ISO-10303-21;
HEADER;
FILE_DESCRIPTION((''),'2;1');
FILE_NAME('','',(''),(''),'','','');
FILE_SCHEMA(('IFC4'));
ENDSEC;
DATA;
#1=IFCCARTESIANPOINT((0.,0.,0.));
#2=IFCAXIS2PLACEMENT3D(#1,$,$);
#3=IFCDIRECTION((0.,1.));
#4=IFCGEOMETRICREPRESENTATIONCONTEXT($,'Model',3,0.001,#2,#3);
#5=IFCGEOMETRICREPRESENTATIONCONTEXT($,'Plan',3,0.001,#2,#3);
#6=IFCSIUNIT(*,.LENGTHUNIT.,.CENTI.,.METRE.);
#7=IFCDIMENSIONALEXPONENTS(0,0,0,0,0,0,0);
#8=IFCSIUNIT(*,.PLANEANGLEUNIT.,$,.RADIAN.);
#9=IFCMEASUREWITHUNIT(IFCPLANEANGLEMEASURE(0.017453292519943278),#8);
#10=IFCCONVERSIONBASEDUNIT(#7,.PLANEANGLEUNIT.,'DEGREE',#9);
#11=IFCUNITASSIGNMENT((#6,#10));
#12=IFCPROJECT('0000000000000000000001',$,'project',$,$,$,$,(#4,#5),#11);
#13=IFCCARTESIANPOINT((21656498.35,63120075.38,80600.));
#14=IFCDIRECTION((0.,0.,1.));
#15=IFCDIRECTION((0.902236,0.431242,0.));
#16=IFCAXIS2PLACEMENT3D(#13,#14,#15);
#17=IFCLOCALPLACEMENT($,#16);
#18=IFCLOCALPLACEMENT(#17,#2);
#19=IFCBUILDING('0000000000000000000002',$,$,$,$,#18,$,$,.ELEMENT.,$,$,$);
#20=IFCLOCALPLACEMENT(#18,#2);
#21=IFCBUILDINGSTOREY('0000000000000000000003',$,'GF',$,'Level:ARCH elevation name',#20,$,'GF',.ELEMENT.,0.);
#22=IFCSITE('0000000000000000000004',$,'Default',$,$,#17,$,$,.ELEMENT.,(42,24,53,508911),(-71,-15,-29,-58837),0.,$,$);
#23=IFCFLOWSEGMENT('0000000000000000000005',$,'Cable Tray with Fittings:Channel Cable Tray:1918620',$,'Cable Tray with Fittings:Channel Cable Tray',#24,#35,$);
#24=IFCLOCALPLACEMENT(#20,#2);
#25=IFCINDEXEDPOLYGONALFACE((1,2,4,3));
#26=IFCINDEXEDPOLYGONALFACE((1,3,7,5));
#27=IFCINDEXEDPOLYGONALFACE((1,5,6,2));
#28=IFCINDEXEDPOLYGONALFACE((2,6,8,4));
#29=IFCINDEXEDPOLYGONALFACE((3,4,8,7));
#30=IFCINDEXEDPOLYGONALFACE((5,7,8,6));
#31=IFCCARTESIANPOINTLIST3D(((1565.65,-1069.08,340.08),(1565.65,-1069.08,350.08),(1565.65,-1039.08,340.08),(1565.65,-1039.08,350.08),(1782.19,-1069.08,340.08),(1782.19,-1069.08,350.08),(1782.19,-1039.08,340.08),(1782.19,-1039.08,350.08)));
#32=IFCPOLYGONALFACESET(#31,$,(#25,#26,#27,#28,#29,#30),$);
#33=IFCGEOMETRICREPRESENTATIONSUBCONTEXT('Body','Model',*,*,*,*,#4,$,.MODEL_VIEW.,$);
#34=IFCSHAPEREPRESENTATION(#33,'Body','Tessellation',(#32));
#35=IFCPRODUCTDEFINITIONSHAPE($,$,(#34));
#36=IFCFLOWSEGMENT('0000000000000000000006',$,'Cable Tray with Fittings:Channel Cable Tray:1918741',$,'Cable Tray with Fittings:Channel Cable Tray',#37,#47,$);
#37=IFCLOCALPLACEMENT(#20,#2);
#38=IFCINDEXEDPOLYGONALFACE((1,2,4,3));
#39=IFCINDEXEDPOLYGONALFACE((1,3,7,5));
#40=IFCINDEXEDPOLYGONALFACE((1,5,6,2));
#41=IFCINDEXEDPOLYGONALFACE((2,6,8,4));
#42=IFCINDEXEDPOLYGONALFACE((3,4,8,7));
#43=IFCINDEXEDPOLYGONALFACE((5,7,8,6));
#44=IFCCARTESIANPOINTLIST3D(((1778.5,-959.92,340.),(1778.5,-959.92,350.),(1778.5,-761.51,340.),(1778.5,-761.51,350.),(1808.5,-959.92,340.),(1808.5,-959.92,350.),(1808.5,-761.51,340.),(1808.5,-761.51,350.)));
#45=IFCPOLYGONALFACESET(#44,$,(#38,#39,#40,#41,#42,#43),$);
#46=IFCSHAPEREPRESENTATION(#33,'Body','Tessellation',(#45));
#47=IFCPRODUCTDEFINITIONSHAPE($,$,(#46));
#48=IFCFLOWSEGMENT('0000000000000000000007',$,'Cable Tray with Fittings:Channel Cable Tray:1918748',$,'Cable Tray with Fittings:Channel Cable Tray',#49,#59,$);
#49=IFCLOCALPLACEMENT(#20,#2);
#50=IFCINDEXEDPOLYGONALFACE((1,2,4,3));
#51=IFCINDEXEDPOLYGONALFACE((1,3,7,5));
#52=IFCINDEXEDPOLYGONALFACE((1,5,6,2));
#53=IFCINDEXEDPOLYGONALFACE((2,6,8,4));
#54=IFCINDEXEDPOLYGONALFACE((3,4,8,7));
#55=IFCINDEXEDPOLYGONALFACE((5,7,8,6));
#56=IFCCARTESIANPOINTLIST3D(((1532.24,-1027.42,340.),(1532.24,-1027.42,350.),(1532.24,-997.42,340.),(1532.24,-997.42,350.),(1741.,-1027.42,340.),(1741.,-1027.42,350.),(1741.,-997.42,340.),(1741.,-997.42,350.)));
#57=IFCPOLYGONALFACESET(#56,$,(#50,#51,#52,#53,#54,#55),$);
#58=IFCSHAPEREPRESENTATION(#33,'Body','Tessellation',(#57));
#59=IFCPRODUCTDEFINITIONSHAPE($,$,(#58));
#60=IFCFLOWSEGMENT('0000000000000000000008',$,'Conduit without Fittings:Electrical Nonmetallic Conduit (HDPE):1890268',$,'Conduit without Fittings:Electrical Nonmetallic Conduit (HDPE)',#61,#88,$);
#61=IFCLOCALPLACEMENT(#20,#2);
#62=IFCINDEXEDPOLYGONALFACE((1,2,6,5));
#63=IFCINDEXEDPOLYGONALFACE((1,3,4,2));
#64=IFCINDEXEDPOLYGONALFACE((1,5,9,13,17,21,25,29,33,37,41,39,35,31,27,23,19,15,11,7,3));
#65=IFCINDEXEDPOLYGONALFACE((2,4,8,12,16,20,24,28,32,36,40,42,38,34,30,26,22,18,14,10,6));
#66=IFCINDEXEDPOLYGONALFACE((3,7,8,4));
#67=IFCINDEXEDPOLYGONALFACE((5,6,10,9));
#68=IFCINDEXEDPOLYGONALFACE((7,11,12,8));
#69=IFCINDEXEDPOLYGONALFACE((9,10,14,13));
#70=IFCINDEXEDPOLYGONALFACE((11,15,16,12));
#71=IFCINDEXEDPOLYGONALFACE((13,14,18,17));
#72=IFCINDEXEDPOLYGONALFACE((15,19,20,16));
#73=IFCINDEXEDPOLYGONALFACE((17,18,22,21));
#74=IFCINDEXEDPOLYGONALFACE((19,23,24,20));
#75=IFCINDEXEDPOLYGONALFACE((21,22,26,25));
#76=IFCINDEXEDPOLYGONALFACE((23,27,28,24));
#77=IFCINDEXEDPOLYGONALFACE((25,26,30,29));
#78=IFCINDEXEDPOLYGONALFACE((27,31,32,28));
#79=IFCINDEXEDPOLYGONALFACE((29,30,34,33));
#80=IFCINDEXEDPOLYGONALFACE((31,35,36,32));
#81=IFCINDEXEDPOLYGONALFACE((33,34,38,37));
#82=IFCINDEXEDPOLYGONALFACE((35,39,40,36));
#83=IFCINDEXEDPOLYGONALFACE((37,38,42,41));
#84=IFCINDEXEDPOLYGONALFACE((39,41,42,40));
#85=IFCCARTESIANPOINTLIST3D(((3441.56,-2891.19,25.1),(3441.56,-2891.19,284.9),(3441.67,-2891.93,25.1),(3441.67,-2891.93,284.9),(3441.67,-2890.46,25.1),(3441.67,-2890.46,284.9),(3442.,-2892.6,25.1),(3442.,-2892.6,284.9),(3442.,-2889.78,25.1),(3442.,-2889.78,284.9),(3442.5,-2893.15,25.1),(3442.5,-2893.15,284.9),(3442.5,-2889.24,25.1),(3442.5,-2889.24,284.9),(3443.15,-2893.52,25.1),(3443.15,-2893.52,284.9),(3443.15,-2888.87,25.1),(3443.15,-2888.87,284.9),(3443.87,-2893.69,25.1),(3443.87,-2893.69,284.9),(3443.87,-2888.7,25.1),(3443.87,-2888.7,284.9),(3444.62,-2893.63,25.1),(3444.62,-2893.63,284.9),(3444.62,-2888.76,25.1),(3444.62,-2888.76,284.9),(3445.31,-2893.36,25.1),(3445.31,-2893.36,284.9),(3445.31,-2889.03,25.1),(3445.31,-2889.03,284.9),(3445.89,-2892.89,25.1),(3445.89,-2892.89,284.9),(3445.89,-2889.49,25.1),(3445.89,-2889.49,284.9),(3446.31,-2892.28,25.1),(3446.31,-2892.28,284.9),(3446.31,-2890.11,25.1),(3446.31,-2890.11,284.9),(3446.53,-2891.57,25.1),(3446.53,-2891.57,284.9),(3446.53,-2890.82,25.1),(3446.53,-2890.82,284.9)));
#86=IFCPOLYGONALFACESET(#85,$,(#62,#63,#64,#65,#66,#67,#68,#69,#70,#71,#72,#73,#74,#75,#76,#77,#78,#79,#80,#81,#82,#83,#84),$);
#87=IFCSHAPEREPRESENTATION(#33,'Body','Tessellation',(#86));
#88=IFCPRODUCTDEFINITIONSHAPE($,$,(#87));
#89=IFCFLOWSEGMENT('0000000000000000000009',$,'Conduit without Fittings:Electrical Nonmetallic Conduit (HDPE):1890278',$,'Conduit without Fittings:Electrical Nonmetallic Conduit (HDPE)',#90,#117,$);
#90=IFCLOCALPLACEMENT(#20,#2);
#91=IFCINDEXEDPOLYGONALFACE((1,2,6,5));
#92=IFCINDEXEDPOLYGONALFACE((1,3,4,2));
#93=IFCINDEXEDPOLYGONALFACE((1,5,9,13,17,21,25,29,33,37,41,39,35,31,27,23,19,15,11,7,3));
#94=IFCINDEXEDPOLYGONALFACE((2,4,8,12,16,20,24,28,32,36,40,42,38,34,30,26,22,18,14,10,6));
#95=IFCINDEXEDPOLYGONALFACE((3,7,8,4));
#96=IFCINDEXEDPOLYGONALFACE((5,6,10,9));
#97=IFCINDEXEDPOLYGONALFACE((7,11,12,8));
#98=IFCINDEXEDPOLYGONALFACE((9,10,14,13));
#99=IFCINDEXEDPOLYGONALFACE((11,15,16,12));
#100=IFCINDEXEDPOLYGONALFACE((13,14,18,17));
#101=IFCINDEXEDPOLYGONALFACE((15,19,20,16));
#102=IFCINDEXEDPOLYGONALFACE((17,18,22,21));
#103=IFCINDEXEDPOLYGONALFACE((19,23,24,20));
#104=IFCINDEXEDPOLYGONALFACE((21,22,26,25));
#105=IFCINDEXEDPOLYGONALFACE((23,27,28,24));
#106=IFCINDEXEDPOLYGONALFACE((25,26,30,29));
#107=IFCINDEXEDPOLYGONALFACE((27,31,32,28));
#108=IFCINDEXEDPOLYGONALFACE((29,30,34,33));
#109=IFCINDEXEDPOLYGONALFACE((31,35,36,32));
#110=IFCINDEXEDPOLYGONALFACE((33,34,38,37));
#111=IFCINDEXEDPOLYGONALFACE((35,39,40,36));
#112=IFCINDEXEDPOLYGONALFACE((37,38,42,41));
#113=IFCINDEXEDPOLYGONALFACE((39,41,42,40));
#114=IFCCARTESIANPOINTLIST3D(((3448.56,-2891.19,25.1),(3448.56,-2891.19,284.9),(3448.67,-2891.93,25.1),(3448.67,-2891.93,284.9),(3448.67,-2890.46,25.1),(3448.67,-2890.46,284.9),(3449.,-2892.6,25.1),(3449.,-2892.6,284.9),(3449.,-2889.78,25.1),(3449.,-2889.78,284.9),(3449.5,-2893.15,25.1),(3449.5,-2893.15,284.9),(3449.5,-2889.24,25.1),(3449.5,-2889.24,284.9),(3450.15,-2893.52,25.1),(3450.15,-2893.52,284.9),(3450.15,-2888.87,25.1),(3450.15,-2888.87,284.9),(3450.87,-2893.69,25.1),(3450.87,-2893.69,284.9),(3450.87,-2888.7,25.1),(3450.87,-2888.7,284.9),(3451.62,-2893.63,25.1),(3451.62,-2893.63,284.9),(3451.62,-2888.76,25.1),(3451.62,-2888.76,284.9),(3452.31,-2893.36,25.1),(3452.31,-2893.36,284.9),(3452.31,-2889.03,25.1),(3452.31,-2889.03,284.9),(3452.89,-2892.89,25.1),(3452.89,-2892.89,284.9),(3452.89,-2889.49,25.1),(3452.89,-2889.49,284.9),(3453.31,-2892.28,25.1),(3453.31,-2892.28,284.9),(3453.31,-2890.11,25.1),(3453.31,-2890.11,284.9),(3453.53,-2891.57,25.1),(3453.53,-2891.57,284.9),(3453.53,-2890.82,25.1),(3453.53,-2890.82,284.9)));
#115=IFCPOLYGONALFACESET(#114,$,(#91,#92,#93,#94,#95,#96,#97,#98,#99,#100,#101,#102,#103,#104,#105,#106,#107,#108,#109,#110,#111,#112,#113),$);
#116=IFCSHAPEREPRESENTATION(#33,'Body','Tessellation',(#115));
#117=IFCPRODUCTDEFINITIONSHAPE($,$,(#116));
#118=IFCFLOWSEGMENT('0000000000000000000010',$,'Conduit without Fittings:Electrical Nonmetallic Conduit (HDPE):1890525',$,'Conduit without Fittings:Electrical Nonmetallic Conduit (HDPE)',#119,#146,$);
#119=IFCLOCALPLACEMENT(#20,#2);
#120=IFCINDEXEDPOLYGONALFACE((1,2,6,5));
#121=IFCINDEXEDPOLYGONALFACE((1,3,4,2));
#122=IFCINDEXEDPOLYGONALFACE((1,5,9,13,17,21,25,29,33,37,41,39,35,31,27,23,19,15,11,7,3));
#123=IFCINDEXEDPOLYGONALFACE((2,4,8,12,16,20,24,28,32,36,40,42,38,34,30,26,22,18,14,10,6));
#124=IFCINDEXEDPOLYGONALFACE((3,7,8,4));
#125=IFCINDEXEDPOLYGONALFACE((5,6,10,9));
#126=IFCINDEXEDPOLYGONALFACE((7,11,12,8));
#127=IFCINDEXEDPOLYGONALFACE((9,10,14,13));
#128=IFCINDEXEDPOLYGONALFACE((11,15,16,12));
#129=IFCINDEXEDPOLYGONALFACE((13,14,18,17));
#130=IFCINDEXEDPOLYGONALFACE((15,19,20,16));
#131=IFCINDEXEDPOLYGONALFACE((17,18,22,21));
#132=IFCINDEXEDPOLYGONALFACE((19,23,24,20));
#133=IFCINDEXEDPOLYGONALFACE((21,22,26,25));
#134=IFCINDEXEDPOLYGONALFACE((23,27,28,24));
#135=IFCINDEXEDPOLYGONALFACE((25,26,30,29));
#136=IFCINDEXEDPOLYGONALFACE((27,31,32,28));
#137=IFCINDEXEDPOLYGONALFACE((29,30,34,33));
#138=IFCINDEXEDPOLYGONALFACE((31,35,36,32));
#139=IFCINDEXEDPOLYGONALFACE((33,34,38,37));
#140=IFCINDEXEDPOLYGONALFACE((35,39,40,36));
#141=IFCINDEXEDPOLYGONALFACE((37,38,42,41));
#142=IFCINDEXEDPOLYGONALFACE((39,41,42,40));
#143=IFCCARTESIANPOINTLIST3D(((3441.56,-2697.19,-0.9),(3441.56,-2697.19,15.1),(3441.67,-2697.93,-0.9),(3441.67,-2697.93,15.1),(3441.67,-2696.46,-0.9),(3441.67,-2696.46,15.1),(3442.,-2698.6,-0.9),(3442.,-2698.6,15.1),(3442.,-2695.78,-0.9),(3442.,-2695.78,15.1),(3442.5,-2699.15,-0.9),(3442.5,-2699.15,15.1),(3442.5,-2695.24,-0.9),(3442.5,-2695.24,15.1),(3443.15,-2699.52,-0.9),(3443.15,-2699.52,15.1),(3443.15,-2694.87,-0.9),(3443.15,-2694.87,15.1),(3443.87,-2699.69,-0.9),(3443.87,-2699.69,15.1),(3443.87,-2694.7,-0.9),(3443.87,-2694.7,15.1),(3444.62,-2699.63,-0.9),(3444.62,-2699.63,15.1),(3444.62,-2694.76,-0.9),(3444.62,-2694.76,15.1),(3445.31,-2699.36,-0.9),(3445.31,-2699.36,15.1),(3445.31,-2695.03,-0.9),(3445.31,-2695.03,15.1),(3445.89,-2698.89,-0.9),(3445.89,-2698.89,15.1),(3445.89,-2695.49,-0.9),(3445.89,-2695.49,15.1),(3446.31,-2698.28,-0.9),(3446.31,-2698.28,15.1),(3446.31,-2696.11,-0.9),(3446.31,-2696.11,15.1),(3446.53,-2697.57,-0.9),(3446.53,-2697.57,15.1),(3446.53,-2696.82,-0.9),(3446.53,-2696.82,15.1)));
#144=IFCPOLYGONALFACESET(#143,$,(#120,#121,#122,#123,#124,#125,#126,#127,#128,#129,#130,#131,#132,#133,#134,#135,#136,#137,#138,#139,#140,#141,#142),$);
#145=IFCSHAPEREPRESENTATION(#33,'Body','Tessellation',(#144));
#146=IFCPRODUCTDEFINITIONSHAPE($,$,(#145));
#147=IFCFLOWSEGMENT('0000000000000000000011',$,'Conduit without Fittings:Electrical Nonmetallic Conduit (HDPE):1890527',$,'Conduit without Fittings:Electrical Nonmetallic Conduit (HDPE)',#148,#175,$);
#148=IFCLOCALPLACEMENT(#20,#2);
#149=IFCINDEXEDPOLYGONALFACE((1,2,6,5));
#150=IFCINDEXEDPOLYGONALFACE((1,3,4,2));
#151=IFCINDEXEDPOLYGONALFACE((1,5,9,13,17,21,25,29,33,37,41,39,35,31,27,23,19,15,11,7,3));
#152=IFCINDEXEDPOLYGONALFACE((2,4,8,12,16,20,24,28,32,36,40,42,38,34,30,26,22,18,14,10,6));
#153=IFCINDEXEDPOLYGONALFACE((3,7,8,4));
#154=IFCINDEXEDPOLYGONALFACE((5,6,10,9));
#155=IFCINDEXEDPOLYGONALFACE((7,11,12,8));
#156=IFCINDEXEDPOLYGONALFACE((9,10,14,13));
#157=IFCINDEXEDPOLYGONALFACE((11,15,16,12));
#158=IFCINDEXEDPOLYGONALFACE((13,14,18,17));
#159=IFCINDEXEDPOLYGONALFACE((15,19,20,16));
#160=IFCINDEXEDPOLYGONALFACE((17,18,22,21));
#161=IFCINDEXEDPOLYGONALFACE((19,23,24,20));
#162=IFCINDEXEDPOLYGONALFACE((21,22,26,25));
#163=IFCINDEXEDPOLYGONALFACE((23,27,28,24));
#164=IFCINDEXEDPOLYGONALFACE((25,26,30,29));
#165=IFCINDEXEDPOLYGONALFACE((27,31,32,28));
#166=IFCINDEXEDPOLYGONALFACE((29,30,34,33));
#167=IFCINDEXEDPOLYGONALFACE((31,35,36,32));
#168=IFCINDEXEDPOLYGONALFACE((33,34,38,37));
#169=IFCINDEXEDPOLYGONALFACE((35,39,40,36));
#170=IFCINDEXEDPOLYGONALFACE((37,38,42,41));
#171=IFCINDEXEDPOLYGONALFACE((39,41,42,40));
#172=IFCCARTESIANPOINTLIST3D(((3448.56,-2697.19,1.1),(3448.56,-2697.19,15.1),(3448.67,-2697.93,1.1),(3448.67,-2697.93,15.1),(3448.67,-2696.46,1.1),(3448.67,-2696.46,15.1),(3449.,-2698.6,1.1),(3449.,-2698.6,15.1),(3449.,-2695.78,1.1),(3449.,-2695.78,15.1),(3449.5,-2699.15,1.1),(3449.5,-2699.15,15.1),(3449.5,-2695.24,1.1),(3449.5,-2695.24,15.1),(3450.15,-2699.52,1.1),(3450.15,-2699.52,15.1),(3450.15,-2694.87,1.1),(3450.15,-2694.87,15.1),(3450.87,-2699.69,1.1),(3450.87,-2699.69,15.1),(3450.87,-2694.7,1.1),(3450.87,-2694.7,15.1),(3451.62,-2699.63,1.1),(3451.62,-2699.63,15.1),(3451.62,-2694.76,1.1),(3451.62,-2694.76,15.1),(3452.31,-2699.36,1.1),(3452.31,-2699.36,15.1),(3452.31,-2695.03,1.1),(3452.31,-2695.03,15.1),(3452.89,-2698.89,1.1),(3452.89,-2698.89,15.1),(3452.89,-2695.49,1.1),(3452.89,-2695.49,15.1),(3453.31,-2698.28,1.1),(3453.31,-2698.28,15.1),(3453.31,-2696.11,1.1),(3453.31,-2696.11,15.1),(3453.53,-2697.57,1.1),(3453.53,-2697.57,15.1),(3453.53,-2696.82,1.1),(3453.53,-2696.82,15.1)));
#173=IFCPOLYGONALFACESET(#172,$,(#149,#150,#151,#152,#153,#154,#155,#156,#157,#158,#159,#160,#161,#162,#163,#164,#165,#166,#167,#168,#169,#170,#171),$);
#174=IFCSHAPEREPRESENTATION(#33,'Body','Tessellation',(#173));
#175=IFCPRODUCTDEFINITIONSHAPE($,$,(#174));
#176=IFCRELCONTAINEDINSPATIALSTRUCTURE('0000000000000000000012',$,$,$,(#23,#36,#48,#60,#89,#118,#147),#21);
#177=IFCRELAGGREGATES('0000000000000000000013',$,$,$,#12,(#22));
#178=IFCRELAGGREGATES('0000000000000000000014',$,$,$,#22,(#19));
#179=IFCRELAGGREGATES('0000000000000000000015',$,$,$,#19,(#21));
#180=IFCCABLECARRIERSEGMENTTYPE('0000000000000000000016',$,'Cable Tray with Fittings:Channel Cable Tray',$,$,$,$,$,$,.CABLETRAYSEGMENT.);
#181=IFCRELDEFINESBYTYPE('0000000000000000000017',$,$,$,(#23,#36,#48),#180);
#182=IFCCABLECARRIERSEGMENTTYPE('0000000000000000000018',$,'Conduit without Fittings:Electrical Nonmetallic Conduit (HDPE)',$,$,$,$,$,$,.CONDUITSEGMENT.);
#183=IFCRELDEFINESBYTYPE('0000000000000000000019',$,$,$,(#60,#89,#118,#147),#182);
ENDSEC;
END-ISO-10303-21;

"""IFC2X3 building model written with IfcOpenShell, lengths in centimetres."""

from ifc_helpers import new_model, entity, si_unit, converted_unit, direction, frame, frame_2d, origin, origin_2d_with_axis, place, context, subcontext, project, spatial, rectangle, circle, extrude, type_object, element, save


model = new_model("IFC2X3")

# Units and contexts
model_context = context("Model", 3, precision=0.001, world=origin(), true_north=direction((0.0, 1.0)))
plan_context = context("Plan", 3, precision=0.001, world=origin(), true_north=direction((0.0, 1.0)))
body_context = subcontext(model_context, "Body", "Model", "MODEL_VIEW")
ifc_project = project(units=[si_unit("LENGTHUNIT", "METRE", prefix="CENTI"), converted_unit("PLANEANGLEUNIT", "DEGREE", entity("IfcPlaneAngleMeasure", 0.017453292519943278), si_unit("PLANEANGLEUNIT", "RADIAN"), dimensions=[0, 0, 0, 0, 0, 0, 0])], contexts=[model_context, plan_context])

# Site, building, storey
site_placement = place(None, frame((21656498.35, 63120075.38, 80600.0), z_axis=(0.0, 0.0, 1.0), x_axis=(0.902236, 0.431242, 0.0)))
site = spatial("IfcSite", under=ifc_project, at=site_placement, Name="Default", CompositionType="ELEMENT", RefLatitude=(42, 24, 53, 508911), RefLongitude=(-71, -15, -29, -58837), RefElevation=0.0)
building_placement = place(site_placement, origin())
building = spatial("IfcBuilding", under=site, at=building_placement, CompositionType="ELEMENT")
storey_placement = place(building_placement, origin())
storey = spatial("IfcBuildingStorey", under=building, at=storey_placement, Name="GF", ObjectType="Level:ARCH elevation name", LongName="GF", CompositionType="ELEMENT", Elevation=0.0)

# Flow segments
cable_carrier_segment_type_1 = type_object("IfcCableCarrierSegmentType", Name="Cable Tray with Fittings:Channel Cable Tray", PredefinedType="CABLETRAYSEGMENT")
flow_segment_1_placement = place(storey_placement, origin())
element("IfcFlowSegment", 1, at=flow_segment_1_placement, inside=storey, type_object=cable_carrier_segment_type_1, Name="Cable Tray with Fittings:Channel Cable Tray:1918620", ObjectType="Cable Tray with Fittings:Channel Cable Tray", context=body_context, shape_type="SweptSolid", body=[
    extrude(rectangle(XDim=216.54, YDim=30.0, at=frame_2d((0.0, 0.0), x_axis=(1.0, 0.0))), frame((1673.92, -1054.08, 340.08), z_axis=(0.0, 0.0, 1.0), x_axis=(-1.0, 0.0, 0.0)), (0.0, 0.0, 1.0), 10.0),
])
flow_segment_2_placement = place(storey_placement, origin())
element("IfcFlowSegment", 2, at=flow_segment_2_placement, inside=storey, type_object=cable_carrier_segment_type_1, Name="Cable Tray with Fittings:Channel Cable Tray:1918741", ObjectType="Cable Tray with Fittings:Channel Cable Tray", context=body_context, shape_type="SweptSolid", body=[
    extrude(rectangle(XDim=198.41, YDim=30.0, at=frame_2d((0.0, 0.0), x_axis=(1.0, 0.0))), frame((1793.5, -860.72, 340.0), z_axis=(0.0, 0.0, 1.0), x_axis=(0.0, -1.0, 0.0)), (0.0, 0.0, 1.0), 10.0),
])
flow_segment_3_placement = place(storey_placement, origin())
element("IfcFlowSegment", 3, at=flow_segment_3_placement, inside=storey, type_object=cable_carrier_segment_type_1, Name="Cable Tray with Fittings:Channel Cable Tray:1918748", ObjectType="Cable Tray with Fittings:Channel Cable Tray", context=body_context, shape_type="SweptSolid", body=[
    extrude(rectangle(XDim=208.76, YDim=30.0, at=origin_2d_with_axis()), frame((1636.62, -1012.42, 340.0)), (0.0, 0.0, 1.0), 10.0),
])
cable_carrier_segment_type_2 = type_object("IfcCableCarrierSegmentType", Name="Conduit without Fittings:Electrical Nonmetallic Conduit (HDPE)", PredefinedType="CONDUITSEGMENT")
flow_segment_4_placement = place(storey_placement, origin())
element("IfcFlowSegment", 4, at=flow_segment_4_placement, inside=storey, type_object=cable_carrier_segment_type_2, Name="Conduit without Fittings:Electrical Nonmetallic Conduit (HDPE):1890268", ObjectType="Conduit without Fittings:Electrical Nonmetallic Conduit (HDPE)", context=body_context, shape_type="SweptSolid", body=[
    extrude(circle(Radius=2.5, at=frame_2d((0.0, 0.0), x_axis=(1.0, 0.0))), frame((3444.06, -2891.19, 25.1), z_axis=(0.0, 0.0, 1.0), x_axis=(-1.0, 0.0, 0.0)), (0.0, 0.0, 1.0), 259.8),
])
flow_segment_5_placement = place(storey_placement, origin())
element("IfcFlowSegment", 5, at=flow_segment_5_placement, inside=storey, type_object=cable_carrier_segment_type_2, Name="Conduit without Fittings:Electrical Nonmetallic Conduit (HDPE):1890278", ObjectType="Conduit without Fittings:Electrical Nonmetallic Conduit (HDPE)", context=body_context, shape_type="SweptSolid", body=[
    extrude(circle(Radius=2.5, at=origin_2d_with_axis()), frame((3451.06, -2891.19, 25.1), z_axis=(0.0, 0.0, 1.0), x_axis=(-1.0, 0.0, 0.0)), (0.0, 0.0, 1.0), 259.8),
])
flow_segment_6_placement = place(storey_placement, origin())
element("IfcFlowSegment", 6, at=flow_segment_6_placement, inside=storey, type_object=cable_carrier_segment_type_2, Name="Conduit without Fittings:Electrical Nonmetallic Conduit (HDPE):1890525", ObjectType="Conduit without Fittings:Electrical Nonmetallic Conduit (HDPE)", context=body_context, shape_type="SweptSolid", body=[
    extrude(circle(Radius=2.5, at=frame_2d((0.0, 0.0), x_axis=(1.0, 0.0))), frame((3444.06, -2697.19, -0.9), z_axis=(0.0, 0.0, 1.0), x_axis=(-1.0, 0.0, 0.0)), (0.0, 0.0, 1.0), 16.0),
])
flow_segment_7_placement = place(storey_placement, origin())
element("IfcFlowSegment", 7, at=flow_segment_7_placement, inside=storey, type_object=cable_carrier_segment_type_2, Name="Conduit without Fittings:Electrical Nonmetallic Conduit (HDPE):1890527", ObjectType="Conduit without Fittings:Electrical Nonmetallic Conduit (HDPE)", context=body_context, shape_type="SweptSolid", body=[
    extrude(circle(Radius=2.5, at=frame_2d((0.0, 0.0), x_axis=(1.0, 0.0))), frame((3451.06, -2697.19, 1.1), z_axis=(0.0, 0.0, 1.0), x_axis=(-1.0, 0.0, 0.0)), (0.0, 0.0, 1.0), 14.0),
])

save(model, "model.ifc")
